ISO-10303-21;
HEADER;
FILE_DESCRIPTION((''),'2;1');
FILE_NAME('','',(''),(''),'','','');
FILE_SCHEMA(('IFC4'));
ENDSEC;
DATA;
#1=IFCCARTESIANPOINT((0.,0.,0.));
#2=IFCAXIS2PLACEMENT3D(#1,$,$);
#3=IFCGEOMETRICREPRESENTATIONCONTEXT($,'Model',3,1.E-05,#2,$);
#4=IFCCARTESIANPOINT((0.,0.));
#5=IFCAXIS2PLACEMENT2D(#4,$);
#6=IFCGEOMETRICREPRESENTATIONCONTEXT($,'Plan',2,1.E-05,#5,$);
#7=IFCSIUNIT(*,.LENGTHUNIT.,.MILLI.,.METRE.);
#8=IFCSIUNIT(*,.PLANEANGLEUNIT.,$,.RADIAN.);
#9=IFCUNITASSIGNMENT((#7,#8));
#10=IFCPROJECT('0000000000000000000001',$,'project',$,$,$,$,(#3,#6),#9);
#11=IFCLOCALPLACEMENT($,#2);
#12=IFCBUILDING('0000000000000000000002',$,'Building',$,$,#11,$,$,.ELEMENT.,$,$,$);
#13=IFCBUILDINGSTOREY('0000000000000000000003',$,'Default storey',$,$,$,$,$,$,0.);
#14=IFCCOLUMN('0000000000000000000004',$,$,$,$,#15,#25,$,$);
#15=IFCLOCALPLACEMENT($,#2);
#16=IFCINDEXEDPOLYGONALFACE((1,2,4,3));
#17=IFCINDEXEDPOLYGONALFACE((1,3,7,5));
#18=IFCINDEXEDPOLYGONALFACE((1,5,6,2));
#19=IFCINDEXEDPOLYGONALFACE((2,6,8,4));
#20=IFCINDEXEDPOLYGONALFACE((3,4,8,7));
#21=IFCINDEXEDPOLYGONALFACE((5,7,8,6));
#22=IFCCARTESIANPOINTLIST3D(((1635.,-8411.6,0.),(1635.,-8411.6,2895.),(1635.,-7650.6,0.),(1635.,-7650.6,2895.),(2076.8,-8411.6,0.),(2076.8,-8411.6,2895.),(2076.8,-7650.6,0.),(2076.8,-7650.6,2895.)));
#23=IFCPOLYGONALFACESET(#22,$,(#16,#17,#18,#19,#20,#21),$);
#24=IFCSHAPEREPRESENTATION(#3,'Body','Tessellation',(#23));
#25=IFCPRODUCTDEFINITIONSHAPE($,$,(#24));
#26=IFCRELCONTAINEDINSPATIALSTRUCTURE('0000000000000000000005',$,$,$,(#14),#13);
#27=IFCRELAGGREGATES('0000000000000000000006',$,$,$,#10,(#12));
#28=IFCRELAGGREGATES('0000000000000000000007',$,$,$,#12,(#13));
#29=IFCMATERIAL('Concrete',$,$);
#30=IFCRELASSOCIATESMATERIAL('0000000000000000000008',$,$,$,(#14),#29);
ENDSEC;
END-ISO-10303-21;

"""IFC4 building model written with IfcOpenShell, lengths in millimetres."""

from ifc_helpers import new_model, si_unit, frame, origin, origin_2d, place, context, project, spatial, rectangle, extrude, material, element, save


model = new_model("IFC4")

# Units and contexts
model_context = context("Model", 3, precision=1e-05, world=origin())
plan_context = context("Plan", 2, precision=1e-05, world=origin_2d())
ifc_project = project(units=[si_unit("LENGTHUNIT", "METRE", prefix="MILLI"), si_unit("PLANEANGLEUNIT", "RADIAN")], contexts=[model_context, plan_context])

# Building, storey
placement = place(None, origin())
building = spatial("IfcBuilding", under=ifc_project, at=placement, Name="Building", CompositionType="ELEMENT")
storey = spatial("IfcBuildingStorey", under=building, Name="Default storey", Elevation=0.0)

# Column
ifc_material_1 = material(Name="Concrete")
element("IfcColumn", 1, at=placement, inside=storey, material=ifc_material_1, context=model_context, shape_type="SweptSolid", body=[
    extrude(rectangle(XDim=441.8, YDim=761.0, at=origin_2d()), frame((1855.9, -8031.1, 0.0), z_axis=(0.0, 0.0, 1.0), x_axis=(1000.0, 0.0, 0.0)), (0.0, 0.0, 1.0), 2895.0),
])

save(model, "model.ifc")
